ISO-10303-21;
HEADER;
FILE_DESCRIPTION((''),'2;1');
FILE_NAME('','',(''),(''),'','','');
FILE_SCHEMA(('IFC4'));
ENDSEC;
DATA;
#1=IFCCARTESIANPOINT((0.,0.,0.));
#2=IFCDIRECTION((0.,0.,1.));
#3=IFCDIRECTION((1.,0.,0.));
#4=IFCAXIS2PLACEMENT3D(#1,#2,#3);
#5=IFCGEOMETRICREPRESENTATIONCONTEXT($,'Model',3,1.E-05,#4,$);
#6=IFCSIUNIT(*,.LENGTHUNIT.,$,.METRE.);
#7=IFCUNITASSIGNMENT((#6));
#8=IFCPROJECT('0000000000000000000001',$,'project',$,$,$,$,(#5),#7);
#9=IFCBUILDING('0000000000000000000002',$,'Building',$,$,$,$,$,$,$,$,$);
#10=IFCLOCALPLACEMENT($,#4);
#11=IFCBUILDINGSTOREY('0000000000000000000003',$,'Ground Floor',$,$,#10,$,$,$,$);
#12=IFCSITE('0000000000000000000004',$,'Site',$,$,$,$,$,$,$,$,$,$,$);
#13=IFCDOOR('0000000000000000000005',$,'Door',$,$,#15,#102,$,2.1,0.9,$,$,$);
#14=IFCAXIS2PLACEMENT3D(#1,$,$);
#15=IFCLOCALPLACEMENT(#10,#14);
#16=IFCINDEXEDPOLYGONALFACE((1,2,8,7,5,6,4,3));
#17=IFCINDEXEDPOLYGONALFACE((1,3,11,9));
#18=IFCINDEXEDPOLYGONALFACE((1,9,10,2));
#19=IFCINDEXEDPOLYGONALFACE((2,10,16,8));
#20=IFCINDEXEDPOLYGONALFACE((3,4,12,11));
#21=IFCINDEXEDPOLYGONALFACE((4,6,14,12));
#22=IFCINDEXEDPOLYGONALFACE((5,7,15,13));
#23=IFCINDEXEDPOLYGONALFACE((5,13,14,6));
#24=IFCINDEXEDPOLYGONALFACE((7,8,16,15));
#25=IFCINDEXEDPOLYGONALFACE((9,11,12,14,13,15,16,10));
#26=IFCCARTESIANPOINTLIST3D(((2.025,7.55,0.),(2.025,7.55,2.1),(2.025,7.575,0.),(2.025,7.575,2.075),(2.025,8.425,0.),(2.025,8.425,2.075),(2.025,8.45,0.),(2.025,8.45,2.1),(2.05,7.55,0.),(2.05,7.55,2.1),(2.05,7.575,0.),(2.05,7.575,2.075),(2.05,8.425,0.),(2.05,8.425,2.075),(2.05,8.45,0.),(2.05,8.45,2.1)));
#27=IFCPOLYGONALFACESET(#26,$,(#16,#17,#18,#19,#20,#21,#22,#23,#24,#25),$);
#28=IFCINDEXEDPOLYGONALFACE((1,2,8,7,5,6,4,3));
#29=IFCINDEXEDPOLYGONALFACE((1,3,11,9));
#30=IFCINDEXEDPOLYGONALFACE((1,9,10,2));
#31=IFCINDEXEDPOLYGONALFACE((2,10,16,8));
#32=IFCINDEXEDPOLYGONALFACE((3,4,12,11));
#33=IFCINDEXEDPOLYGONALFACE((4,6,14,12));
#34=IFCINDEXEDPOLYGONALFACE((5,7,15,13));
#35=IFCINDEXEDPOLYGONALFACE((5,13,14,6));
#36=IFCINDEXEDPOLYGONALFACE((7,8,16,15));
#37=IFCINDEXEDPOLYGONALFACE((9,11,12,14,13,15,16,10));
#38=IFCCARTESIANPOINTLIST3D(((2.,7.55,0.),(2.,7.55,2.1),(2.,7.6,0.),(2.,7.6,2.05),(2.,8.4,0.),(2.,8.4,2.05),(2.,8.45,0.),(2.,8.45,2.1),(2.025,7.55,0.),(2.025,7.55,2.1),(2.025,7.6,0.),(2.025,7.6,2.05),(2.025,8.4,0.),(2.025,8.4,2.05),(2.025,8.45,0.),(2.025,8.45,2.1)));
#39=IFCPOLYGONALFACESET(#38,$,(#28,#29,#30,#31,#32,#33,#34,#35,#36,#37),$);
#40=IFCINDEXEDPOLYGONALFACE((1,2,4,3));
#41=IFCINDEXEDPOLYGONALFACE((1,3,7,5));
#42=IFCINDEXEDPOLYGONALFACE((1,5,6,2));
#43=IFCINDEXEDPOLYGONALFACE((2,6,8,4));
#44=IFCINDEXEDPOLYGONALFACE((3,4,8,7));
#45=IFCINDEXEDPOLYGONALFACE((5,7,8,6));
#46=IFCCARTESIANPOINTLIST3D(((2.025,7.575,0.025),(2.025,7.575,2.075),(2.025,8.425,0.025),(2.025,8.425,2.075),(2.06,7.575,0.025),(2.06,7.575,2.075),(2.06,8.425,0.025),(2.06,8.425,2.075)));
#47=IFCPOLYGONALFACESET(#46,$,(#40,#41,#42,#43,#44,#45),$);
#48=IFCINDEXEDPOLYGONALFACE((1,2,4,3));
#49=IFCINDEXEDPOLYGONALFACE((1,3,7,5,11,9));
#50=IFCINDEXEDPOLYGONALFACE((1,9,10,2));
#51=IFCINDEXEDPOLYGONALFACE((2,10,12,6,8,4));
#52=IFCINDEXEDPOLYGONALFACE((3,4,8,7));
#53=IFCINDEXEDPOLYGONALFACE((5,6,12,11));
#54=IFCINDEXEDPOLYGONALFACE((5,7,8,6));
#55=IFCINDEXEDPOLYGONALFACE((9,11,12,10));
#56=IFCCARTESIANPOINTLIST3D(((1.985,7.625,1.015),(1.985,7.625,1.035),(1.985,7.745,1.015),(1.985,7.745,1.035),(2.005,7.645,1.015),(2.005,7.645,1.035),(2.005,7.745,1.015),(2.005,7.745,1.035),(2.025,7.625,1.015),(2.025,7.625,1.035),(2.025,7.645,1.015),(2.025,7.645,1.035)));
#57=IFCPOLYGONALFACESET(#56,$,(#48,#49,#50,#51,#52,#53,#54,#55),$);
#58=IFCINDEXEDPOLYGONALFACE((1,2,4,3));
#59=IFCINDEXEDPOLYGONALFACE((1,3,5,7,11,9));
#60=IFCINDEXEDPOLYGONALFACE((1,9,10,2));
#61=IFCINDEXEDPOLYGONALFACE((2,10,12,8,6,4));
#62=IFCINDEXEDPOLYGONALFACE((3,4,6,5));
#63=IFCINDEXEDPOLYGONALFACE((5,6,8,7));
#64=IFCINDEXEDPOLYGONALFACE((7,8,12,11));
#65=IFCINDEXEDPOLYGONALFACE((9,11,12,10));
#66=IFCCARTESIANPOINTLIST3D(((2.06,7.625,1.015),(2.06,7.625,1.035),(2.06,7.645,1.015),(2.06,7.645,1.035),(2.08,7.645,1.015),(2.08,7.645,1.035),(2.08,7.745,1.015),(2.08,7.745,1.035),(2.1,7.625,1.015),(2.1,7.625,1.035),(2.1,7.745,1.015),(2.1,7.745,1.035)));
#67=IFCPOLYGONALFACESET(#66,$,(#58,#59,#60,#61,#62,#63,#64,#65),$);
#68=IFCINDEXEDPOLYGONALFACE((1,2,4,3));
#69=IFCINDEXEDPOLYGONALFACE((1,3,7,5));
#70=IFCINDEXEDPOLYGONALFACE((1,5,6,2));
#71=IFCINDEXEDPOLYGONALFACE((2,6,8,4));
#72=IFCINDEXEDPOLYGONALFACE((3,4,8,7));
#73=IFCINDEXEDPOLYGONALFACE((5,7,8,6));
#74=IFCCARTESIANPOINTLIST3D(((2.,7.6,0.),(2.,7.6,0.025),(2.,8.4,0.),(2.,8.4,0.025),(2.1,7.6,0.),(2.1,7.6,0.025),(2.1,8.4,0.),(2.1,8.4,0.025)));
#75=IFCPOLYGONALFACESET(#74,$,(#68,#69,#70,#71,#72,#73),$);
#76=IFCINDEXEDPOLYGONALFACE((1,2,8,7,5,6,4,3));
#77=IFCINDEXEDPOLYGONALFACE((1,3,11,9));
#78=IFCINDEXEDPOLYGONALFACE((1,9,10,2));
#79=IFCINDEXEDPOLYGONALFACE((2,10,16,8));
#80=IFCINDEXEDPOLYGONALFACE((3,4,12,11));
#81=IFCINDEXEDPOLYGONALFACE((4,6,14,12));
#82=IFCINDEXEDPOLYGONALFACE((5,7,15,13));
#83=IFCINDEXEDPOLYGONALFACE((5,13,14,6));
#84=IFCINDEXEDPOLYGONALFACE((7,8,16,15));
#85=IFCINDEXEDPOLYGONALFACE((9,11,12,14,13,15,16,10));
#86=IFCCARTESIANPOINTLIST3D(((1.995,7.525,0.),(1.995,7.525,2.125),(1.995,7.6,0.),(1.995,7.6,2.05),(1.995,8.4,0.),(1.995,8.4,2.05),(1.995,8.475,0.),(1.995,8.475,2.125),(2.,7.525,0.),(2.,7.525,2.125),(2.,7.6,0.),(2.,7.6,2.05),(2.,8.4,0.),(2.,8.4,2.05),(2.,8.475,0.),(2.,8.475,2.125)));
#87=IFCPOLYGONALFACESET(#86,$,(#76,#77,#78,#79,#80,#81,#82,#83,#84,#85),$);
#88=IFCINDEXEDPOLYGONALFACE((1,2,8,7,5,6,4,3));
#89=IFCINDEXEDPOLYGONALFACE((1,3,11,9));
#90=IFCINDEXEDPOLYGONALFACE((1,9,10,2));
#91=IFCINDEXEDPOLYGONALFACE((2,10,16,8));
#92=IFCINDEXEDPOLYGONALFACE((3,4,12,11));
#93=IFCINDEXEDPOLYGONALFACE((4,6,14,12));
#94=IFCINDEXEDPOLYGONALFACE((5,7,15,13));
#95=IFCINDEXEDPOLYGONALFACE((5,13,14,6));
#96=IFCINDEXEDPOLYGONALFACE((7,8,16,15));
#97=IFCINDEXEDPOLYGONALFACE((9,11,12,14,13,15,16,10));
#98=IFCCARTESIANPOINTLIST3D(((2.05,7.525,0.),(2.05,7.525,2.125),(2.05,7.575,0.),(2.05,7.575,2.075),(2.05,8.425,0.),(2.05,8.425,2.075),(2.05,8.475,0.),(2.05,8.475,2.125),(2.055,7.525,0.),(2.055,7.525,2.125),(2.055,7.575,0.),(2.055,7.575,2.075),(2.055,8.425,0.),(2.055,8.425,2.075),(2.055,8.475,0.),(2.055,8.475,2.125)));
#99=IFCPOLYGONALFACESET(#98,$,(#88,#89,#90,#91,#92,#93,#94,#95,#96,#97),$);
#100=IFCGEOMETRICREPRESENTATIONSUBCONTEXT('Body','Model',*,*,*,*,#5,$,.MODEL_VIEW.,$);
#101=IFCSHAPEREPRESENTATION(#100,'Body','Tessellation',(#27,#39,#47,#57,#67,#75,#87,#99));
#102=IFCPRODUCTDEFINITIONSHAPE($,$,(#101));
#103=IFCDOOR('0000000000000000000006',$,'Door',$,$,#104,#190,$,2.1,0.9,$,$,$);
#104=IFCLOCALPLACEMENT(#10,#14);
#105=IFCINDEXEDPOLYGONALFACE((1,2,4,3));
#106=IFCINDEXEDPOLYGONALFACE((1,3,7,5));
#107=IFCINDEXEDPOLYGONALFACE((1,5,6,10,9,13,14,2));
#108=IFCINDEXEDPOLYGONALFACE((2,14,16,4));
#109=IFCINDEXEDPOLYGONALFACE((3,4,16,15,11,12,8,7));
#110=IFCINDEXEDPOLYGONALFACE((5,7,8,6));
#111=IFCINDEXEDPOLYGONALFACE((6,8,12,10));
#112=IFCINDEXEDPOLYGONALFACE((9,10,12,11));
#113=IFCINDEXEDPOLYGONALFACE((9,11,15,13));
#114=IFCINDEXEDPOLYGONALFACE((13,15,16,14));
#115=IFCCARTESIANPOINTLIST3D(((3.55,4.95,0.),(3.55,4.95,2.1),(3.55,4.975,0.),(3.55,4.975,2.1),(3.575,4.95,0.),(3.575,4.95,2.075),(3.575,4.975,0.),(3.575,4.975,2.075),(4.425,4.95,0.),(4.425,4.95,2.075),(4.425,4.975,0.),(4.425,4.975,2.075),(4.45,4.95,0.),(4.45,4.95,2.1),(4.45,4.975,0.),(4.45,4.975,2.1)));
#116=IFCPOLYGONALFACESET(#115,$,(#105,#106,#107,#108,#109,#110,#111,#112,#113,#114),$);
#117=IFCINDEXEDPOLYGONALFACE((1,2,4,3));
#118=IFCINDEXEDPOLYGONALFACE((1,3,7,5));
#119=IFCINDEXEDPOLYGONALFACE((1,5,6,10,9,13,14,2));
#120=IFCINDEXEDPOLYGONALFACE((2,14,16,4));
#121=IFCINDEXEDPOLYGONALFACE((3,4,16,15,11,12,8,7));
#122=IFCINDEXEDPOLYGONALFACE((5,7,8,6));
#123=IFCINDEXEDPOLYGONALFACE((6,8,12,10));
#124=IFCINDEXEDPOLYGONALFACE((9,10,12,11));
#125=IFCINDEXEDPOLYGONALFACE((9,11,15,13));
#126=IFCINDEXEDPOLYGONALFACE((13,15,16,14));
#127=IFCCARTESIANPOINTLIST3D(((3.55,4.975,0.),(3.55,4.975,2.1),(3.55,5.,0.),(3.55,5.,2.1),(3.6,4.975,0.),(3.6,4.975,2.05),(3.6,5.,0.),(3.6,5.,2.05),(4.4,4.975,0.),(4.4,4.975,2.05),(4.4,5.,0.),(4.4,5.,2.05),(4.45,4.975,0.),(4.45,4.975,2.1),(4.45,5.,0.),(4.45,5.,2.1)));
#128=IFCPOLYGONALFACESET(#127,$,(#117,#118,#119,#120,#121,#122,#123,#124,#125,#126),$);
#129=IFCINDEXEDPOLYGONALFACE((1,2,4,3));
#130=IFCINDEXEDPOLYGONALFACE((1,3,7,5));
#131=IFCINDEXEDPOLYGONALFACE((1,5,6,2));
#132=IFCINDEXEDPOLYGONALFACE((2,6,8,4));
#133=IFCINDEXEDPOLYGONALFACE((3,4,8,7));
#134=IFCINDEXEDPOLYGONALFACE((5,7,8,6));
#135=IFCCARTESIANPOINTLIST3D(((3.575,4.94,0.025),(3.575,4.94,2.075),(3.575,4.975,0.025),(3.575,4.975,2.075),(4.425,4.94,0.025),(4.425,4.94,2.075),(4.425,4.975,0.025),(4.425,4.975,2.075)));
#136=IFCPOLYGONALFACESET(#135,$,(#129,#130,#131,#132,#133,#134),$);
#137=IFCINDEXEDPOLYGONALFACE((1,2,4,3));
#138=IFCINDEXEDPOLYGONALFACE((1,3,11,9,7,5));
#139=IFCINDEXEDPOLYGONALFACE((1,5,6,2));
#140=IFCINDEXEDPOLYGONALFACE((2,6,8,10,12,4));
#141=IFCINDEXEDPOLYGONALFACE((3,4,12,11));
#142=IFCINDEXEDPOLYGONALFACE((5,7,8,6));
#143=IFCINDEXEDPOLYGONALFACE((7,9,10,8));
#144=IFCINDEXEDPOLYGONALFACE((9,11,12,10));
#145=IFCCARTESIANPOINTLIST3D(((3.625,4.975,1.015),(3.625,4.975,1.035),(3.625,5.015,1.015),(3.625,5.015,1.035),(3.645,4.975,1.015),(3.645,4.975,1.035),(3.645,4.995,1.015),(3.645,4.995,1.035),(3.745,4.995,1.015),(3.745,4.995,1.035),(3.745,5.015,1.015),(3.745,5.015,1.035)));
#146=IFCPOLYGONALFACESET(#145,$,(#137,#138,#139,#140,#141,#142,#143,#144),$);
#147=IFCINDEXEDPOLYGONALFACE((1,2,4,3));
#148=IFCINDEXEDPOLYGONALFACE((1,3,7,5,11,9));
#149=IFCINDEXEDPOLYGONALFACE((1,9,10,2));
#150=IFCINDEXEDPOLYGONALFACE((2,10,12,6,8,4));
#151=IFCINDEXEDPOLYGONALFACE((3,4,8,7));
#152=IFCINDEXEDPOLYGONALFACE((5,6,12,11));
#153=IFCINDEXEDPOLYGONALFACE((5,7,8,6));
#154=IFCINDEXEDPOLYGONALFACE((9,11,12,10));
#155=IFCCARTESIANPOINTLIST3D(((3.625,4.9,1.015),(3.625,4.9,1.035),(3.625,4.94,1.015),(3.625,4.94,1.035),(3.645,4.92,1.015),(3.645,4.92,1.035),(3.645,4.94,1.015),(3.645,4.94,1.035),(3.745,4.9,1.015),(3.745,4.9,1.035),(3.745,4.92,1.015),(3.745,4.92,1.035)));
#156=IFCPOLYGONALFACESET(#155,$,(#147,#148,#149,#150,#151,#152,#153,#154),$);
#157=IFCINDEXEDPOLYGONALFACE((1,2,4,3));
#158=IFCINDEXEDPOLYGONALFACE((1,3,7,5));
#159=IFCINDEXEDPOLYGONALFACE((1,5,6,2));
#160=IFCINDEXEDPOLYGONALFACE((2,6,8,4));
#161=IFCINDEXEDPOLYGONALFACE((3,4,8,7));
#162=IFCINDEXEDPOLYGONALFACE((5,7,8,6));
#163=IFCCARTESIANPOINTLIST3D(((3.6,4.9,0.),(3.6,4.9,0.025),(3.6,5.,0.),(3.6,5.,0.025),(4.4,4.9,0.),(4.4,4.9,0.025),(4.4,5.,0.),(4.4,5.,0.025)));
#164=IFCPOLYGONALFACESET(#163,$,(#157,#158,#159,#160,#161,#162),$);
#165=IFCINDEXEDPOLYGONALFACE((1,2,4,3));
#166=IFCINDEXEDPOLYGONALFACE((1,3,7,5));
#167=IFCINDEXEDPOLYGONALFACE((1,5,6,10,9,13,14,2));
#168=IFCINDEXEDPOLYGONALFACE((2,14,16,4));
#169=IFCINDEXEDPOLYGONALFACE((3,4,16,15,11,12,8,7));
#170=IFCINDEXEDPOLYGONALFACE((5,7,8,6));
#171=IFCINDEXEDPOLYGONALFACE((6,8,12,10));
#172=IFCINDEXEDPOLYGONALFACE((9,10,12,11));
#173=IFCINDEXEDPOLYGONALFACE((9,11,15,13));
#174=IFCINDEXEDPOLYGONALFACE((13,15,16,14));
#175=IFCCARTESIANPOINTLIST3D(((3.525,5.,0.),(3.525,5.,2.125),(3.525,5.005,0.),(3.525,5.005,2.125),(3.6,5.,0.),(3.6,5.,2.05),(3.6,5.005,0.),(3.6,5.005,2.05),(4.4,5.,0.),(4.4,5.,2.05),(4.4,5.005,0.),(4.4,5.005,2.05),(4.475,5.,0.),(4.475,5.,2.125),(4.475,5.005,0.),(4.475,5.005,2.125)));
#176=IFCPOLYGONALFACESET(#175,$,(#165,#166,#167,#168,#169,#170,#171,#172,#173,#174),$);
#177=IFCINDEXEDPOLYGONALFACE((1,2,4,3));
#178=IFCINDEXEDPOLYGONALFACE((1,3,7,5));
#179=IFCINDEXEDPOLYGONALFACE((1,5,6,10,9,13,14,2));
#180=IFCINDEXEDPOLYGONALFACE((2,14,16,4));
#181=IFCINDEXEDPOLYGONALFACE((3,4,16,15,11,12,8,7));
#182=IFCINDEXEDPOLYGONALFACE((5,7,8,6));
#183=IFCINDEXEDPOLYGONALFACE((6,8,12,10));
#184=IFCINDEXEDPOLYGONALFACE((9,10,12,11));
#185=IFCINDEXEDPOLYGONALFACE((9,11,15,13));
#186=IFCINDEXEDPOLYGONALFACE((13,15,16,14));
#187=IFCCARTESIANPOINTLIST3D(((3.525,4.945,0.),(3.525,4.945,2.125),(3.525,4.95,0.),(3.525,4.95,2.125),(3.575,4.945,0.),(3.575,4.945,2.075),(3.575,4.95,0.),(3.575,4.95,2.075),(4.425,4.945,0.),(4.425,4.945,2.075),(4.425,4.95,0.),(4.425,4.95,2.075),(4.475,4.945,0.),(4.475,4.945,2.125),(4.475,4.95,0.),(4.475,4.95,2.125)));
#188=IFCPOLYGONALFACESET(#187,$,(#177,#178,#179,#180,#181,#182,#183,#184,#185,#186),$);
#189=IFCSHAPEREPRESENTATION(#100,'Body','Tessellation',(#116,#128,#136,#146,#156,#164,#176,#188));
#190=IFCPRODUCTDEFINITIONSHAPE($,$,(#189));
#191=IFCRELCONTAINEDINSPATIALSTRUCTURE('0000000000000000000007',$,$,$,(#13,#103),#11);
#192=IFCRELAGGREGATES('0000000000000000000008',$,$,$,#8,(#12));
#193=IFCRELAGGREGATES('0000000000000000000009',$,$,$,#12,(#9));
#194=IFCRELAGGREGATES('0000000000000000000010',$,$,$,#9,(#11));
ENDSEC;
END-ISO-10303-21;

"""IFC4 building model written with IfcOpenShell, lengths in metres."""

from ifc_helpers import new_model, si_unit, frame, origin_with_axes, place, context, subcontext, project, spatial, line, indexed_curve, outline, extrude, element, save


model = new_model("IFC4")

# Units and contexts
model_context = context("Model", 3, precision=1e-05, world=origin_with_axes())
body_context = subcontext(model_context, "Body", "Model", "MODEL_VIEW")
ifc_project = project(units=[si_unit("LENGTHUNIT", "METRE")], contexts=[model_context])

# Site, building, storey
site = spatial("IfcSite", under=ifc_project, Name="Site")
building = spatial("IfcBuilding", under=site, Name="Building")
storey_placement = place(None, origin_with_axes())
storey = spatial("IfcBuildingStorey", under=building, at=storey_placement, Name="Ground Floor")

# Doors
door_1_placement = place(storey_placement, frame((2.0, 8.45, 0.0), z_axis=(0.0, 0.0, 1.0), x_axis=(0.0, -1.0, 0.0)))
element("IfcDoor", 1, at=door_1_placement, inside=storey, Name="Door", OverallHeight=2.1, OverallWidth=0.9, context=body_context, shape_type="SweptSolid", body=[
    extrude(outline(indexed_curve([(0.0, 0.0), (0.0, 2.1), (0.9, 2.1), (0.9, 0.0), (0.875, 0.0), (0.875, 2.075), (0.025, 2.075), (0.025, 0.0)], segments=[line(1, 2, 3, 4, 5, 6, 7, 8, 1)])), frame((0.0, 0.025, 0.0), z_axis=(0.0, -1.0, 0.0), x_axis=(1.0, 0.0, 0.0)), (0.0, 0.0, -1.0), 0.025),
    extrude(outline(indexed_curve([(0.0, 0.0), (0.0, 2.1), (0.9, 2.1), (0.9, 0.0), (0.85, 0.0), (0.85, 2.05), (0.05, 2.05), (0.05, 0.0)], segments=[line(1, 2, 3, 4, 5, 6, 7, 8, 1)])), frame((0.0, 0.0, 0.0), z_axis=(0.0, -1.0, 0.0), x_axis=(1.0, 0.0, 0.0)), (0.0, 0.0, -1.0), 0.025),
    extrude(outline(indexed_curve([(0.0, 0.0), (0.85, 0.0), (0.85, 0.035), (0.0, 0.035)], segments=[line(1, 2, 3, 4, 1)])), frame((0.025, 0.025, 0.025), z_axis=(0.0, 0.0, 1.0), x_axis=(1.0, 0.0, 0.0)), (0.0, 0.0, 1.0), 2.05),
    extrude(outline(indexed_curve([(0.0, 0.0), (0.0, -0.04), (-0.12, -0.04), (-0.12, -0.02), (-0.02, -0.02), (-0.02, 0.0)], segments=[line(1, 2, 3, 4, 5, 6, 1)])), frame((0.825, 0.025, 1.015), z_axis=(0.0, 0.0, 1.0), x_axis=(1.0, 0.0, 0.0)), (0.0, 0.0, 1.0), 0.02),
    extrude(outline(indexed_curve([(0.0, 0.0), (0.0, 0.04), (-0.12, 0.04), (-0.12, 0.02), (-0.02, 0.02), (-0.02, 0.0)], segments=[line(1, 2, 3, 4, 5, 6, 1)])), frame((0.825, 0.06, 1.015), z_axis=(0.0, 0.0, 1.0), x_axis=(1.0, 0.0, 0.0)), (0.0, 0.0, 1.0), 0.02),
    extrude(outline(indexed_curve([(0.0, 0.0), (0.8, 0.0), (0.8, 0.1), (0.0, 0.1)], segments=[line(1, 2, 3, 4, 1)])), frame((0.05, 0.0, 0.0), z_axis=(0.0, 0.0, 1.0), x_axis=(1.0, 0.0, 0.0)), (0.0, 0.0, 1.0), 0.025),
    extrude(outline(indexed_curve([(0.0, 0.0), (0.0, 2.125), (0.95, 2.125), (0.95, 0.0), (0.875, 0.0), (0.875, 2.05), (0.075, 2.05), (0.075, 0.0)], segments=[line(1, 2, 3, 4, 5, 6, 7, 8, 1)])), frame((-0.025, -0.005, 0.0), z_axis=(0.0, -1.0, 0.0), x_axis=(1.0, 0.0, 0.0)), (0.0, 0.0, -1.0), 0.005),
    extrude(outline(indexed_curve([(0.0, 0.0), (0.0, 2.125), (0.95, 2.125), (0.95, 0.0), (0.9, 0.0), (0.9, 2.075), (0.05, 2.075), (0.05, 0.0)], segments=[line(1, 2, 3, 4, 5, 6, 7, 8, 1)])), frame((-0.025, 0.05, 0.0), z_axis=(0.0, -1.0, 0.0), x_axis=(1.0, 0.0, 0.0)), (0.0, 0.0, -1.0), 0.005),
])
door_2_placement = place(storey_placement, frame((4.45, 5.0, 0.0), z_axis=(0.0, 0.0, 1.0), x_axis=(-1.0, 0.0, 0.0)))
element("IfcDoor", 2, at=door_2_placement, inside=storey, Name="Door", OverallHeight=2.1, OverallWidth=0.9, context=body_context, shape_type="SweptSolid", body=[
    extrude(outline(indexed_curve([(0.0, 0.0), (0.0, 2.1), (0.9, 2.1), (0.9, 0.0), (0.875, 0.0), (0.875, 2.075), (0.025, 2.075), (0.025, 0.0)], segments=[line(1, 2, 3, 4, 5, 6, 7, 8, 1)])), frame((0.0, 0.025, 0.0), z_axis=(0.0, -1.0, 0.0), x_axis=(1.0, 0.0, 0.0)), (0.0, 0.0, -1.0), 0.025),
    extrude(outline(indexed_curve([(0.0, 0.0), (0.0, 2.1), (0.9, 2.1), (0.9, 0.0), (0.85, 0.0), (0.85, 2.05), (0.05, 2.05), (0.05, 0.0)], segments=[line(1, 2, 3, 4, 5, 6, 7, 8, 1)])), frame((0.0, 0.0, 0.0), z_axis=(0.0, -1.0, 0.0), x_axis=(1.0, 0.0, 0.0)), (0.0, 0.0, -1.0), 0.025),
    extrude(outline(indexed_curve([(0.0, 0.0), (0.85, 0.0), (0.85, 0.035), (0.0, 0.035)], segments=[line(1, 2, 3, 4, 1)])), frame((0.025, 0.025, 0.025), z_axis=(0.0, 0.0, 1.0), x_axis=(1.0, 0.0, 0.0)), (0.0, 0.0, 1.0), 2.05),
    extrude(outline(indexed_curve([(0.0, 0.0), (0.0, -0.04), (-0.12, -0.04), (-0.12, -0.02), (-0.02, -0.02), (-0.02, 0.0)], segments=[line(1, 2, 3, 4, 5, 6, 1)])), frame((0.825, 0.025, 1.015), z_axis=(0.0, 0.0, 1.0), x_axis=(1.0, 0.0, 0.0)), (0.0, 0.0, 1.0), 0.02),
    extrude(outline(indexed_curve([(0.0, 0.0), (0.0, 0.04), (-0.12, 0.04), (-0.12, 0.02), (-0.02, 0.02), (-0.02, 0.0)], segments=[line(1, 2, 3, 4, 5, 6, 1)])), frame((0.825, 0.06, 1.015), z_axis=(0.0, 0.0, 1.0), x_axis=(1.0, 0.0, 0.0)), (0.0, 0.0, 1.0), 0.02),
    extrude(outline(indexed_curve([(0.0, 0.0), (0.8, 0.0), (0.8, 0.1), (0.0, 0.1)], segments=[line(1, 2, 3, 4, 1)])), frame((0.05, 0.0, 0.0), z_axis=(0.0, 0.0, 1.0), x_axis=(1.0, 0.0, 0.0)), (0.0, 0.0, 1.0), 0.025),
    extrude(outline(indexed_curve([(0.0, 0.0), (0.0, 2.125), (0.95, 2.125), (0.95, 0.0), (0.875, 0.0), (0.875, 2.05), (0.075, 2.05), (0.075, 0.0)], segments=[line(1, 2, 3, 4, 5, 6, 7, 8, 1)])), frame((-0.025, -0.005, 0.0), z_axis=(0.0, -1.0, 0.0), x_axis=(1.0, 0.0, 0.0)), (0.0, 0.0, -1.0), 0.005),
    extrude(outline(indexed_curve([(0.0, 0.0), (0.0, 2.125), (0.95, 2.125), (0.95, 0.0), (0.9, 0.0), (0.9, 2.075), (0.05, 2.075), (0.05, 0.0)], segments=[line(1, 2, 3, 4, 5, 6, 7, 8, 1)])), frame((-0.025, 0.05, 0.0), z_axis=(0.0, -1.0, 0.0), x_axis=(1.0, 0.0, 0.0)), (0.0, 0.0, -1.0), 0.005),
])

save(model, "model.ifc")
